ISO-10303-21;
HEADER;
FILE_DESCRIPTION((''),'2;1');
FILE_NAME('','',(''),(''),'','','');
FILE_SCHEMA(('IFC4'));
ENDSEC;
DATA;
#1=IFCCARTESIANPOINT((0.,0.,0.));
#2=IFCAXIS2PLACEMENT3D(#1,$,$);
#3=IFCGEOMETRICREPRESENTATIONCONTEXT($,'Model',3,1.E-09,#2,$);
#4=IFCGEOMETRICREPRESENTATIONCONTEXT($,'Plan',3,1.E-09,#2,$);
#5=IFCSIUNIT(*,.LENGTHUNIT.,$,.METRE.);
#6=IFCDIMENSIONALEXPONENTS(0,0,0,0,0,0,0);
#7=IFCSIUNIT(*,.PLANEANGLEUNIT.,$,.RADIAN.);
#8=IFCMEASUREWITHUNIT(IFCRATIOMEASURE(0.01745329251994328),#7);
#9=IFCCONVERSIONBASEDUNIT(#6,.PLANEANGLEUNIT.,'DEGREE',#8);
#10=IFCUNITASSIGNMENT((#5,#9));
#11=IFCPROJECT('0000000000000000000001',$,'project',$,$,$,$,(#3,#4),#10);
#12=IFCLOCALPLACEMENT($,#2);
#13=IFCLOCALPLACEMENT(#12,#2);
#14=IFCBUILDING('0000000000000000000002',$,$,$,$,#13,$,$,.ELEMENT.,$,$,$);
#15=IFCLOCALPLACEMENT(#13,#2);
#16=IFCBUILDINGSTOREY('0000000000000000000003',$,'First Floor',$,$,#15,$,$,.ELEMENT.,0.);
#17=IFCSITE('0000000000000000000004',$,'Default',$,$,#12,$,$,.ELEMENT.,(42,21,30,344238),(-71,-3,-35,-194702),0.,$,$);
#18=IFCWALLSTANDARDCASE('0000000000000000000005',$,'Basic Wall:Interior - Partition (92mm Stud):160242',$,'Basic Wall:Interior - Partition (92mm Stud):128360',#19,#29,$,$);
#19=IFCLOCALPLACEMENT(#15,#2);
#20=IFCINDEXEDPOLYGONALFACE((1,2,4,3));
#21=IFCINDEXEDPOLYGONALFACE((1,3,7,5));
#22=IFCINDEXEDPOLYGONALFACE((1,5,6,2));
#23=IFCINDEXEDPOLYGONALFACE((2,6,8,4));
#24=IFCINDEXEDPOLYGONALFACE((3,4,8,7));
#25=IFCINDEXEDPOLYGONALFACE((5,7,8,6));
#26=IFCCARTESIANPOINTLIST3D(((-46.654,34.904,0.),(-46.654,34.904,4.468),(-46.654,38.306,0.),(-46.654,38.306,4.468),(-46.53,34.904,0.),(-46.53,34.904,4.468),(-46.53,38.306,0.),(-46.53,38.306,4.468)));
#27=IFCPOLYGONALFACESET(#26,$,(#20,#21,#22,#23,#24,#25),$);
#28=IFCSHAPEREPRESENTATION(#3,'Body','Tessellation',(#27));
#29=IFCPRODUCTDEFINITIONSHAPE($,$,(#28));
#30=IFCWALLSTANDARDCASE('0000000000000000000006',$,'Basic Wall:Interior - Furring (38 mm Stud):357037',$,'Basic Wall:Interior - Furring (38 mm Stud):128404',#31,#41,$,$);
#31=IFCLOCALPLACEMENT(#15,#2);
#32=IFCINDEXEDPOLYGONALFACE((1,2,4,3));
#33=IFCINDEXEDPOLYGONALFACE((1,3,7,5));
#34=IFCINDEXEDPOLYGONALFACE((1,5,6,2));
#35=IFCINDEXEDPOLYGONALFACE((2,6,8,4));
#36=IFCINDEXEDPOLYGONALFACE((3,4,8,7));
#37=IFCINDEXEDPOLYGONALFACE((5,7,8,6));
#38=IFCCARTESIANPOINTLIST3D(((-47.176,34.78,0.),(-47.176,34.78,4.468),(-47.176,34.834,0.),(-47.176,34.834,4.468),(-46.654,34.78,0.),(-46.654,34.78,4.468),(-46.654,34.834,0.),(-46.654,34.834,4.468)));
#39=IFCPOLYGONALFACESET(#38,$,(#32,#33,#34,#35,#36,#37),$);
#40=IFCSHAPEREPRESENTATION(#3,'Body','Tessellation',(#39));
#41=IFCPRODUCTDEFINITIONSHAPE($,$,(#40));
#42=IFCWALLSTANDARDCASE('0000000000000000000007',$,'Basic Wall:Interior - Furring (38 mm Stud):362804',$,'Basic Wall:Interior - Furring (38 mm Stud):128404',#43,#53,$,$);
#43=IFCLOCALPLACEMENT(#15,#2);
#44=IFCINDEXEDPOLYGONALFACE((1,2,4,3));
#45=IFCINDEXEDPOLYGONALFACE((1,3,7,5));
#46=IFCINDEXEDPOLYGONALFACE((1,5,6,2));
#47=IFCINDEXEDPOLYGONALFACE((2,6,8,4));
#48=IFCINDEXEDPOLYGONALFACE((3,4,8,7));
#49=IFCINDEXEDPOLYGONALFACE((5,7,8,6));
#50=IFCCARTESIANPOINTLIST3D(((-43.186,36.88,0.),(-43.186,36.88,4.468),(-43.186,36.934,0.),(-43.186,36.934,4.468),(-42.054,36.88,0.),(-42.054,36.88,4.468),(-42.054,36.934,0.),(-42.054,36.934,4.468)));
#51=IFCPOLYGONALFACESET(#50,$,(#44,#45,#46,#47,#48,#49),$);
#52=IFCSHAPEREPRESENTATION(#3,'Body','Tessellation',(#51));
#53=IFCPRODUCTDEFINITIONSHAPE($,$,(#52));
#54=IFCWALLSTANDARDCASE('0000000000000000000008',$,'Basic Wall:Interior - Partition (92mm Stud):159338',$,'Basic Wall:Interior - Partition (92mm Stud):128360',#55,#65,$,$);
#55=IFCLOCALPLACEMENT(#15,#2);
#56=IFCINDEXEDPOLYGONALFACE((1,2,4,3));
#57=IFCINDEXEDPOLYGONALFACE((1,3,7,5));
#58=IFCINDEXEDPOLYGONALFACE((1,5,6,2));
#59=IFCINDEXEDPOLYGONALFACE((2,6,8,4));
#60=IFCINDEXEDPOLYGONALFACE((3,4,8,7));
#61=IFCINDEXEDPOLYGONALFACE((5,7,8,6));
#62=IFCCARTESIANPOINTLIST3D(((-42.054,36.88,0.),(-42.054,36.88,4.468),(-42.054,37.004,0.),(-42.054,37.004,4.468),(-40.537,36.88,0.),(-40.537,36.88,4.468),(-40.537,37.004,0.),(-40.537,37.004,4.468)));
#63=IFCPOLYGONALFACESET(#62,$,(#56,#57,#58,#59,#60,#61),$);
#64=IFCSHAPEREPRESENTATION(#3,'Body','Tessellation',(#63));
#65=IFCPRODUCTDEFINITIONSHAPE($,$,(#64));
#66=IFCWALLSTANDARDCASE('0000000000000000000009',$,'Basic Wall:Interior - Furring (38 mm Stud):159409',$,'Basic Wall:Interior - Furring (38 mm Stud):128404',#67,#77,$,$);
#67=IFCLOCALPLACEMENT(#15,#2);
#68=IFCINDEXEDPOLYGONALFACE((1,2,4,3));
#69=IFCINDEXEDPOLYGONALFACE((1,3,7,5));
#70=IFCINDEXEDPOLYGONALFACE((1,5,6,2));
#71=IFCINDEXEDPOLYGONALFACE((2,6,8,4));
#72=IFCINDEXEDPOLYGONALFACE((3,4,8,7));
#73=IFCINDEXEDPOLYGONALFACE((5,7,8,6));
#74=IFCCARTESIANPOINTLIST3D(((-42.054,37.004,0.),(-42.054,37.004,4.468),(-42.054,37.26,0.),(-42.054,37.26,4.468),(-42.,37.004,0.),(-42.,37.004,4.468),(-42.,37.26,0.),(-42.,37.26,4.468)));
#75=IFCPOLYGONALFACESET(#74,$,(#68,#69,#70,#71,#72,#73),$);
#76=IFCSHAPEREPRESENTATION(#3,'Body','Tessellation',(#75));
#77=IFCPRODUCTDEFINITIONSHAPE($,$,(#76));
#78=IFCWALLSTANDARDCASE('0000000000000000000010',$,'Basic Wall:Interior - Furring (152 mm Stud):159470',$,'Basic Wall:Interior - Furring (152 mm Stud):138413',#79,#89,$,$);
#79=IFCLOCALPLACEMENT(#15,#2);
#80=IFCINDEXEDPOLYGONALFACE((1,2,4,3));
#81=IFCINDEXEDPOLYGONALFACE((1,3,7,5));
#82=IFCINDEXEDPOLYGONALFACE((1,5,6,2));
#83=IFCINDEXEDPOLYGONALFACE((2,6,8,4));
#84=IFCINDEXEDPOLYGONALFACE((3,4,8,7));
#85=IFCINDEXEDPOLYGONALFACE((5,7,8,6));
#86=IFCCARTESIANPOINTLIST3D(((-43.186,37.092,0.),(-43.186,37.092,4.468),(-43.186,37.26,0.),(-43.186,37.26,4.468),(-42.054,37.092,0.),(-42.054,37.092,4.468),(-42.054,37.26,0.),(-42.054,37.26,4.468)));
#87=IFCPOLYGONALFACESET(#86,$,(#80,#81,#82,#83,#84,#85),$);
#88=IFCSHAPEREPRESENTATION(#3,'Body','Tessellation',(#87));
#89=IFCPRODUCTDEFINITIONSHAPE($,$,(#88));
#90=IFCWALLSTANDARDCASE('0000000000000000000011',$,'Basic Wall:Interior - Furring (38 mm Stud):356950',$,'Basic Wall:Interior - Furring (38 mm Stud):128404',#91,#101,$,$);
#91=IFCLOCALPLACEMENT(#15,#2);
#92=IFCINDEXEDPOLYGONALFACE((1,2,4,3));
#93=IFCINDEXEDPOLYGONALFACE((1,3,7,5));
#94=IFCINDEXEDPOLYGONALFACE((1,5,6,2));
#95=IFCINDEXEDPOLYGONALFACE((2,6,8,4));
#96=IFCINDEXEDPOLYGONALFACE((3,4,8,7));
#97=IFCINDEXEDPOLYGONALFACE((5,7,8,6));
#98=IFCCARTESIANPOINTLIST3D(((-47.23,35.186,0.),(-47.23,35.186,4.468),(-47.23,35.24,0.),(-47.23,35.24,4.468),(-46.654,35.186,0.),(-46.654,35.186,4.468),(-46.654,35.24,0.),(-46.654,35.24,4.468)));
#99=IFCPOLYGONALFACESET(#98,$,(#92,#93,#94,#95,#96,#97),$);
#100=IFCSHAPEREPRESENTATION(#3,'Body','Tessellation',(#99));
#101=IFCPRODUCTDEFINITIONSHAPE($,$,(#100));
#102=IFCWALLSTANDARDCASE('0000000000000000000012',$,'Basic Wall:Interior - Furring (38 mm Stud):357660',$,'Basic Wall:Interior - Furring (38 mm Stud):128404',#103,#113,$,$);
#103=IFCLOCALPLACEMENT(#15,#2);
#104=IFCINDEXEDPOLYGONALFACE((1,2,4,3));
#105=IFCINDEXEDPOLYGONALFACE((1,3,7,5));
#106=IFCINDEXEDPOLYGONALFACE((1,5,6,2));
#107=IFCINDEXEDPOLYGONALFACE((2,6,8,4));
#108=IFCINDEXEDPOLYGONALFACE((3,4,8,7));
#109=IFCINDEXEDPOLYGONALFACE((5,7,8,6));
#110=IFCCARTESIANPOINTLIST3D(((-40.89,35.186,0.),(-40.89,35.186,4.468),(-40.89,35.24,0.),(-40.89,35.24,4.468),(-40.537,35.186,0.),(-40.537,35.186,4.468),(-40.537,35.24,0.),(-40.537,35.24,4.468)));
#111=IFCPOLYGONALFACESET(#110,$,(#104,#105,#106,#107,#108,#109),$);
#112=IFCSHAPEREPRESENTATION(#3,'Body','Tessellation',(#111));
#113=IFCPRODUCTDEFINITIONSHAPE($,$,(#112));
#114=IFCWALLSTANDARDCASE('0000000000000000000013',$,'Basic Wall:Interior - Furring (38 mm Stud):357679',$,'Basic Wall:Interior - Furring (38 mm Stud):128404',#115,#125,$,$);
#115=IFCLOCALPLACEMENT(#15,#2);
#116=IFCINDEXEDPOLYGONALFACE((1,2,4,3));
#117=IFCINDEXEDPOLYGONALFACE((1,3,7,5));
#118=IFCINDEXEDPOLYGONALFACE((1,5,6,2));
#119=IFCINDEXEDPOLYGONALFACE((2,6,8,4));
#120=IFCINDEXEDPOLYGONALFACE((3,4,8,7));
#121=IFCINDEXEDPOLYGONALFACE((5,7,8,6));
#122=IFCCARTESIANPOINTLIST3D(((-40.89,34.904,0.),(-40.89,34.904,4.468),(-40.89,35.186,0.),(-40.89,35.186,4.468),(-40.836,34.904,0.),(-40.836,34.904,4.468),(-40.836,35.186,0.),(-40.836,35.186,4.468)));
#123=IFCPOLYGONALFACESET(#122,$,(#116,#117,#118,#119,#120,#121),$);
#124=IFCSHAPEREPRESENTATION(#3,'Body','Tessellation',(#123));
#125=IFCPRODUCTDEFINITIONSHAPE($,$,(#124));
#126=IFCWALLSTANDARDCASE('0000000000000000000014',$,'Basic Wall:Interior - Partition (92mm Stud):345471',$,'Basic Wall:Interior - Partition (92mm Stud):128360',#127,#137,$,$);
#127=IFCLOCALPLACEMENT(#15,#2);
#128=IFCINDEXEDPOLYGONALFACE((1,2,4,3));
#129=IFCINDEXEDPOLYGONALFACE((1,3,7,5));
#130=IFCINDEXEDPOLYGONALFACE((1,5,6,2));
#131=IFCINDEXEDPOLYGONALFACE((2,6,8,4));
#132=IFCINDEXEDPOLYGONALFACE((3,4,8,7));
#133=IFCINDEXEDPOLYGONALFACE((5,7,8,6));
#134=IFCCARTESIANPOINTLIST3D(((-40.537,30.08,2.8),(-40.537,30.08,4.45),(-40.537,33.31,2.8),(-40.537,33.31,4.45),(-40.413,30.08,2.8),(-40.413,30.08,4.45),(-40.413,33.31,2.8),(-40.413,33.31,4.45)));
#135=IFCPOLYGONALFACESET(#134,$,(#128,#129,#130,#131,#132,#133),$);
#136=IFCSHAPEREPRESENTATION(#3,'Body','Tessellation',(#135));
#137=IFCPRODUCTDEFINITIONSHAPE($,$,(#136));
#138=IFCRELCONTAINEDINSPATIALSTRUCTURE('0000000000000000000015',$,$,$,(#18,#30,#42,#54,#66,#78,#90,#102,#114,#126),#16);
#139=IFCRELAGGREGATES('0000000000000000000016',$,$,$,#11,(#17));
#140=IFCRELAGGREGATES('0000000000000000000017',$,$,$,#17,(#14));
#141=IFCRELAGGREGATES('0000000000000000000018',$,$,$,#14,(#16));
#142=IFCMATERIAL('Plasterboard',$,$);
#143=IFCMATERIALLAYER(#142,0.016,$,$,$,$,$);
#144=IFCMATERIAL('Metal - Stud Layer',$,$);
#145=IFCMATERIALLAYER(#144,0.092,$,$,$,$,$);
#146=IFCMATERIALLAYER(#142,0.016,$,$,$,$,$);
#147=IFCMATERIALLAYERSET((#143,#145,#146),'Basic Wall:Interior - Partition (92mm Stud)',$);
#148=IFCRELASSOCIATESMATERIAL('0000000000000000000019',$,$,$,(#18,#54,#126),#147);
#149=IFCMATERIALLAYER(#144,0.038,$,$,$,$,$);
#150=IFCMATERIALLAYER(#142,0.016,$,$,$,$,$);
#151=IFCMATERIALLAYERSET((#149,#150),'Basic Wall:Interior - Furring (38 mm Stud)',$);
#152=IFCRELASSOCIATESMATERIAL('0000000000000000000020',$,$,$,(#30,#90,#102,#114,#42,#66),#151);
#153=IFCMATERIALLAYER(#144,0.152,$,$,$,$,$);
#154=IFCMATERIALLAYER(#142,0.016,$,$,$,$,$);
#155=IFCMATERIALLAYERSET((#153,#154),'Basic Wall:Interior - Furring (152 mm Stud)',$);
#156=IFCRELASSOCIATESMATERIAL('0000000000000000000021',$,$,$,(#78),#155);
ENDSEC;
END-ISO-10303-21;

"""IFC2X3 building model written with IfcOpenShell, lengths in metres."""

from ifc_helpers import new_model, entity, si_unit, converted_unit, frame, frame_2d, origin, place, context, project, spatial, rectangle, extrude, material, layer, layer_set, layer_usage, element, save


model = new_model("IFC2X3")

# Units and contexts
model_context = context("Model", 3, precision=1e-09, world=origin())
plan_context = context("Plan", 3, precision=1e-09, world=origin())
ifc_project = project(units=[si_unit("LENGTHUNIT", "METRE"), converted_unit("PLANEANGLEUNIT", "DEGREE", entity("IfcRatioMeasure", 0.01745329251994328), si_unit("PLANEANGLEUNIT", "RADIAN"), dimensions=[0, 0, 0, 0, 0, 0, 0])], contexts=[model_context, plan_context])

# Site, building, storey
site_placement = place(None, origin())
site = spatial("IfcSite", under=ifc_project, at=site_placement, Name="Default", CompositionType="ELEMENT", RefLatitude=(42, 21, 30, 344238), RefLongitude=(-71, -3, -35, -194702), RefElevation=0.0)
building_placement = place(site_placement, origin())
building = spatial("IfcBuilding", under=site, at=building_placement, CompositionType="ELEMENT")
storey_placement = place(building_placement, origin())
storey = spatial("IfcBuildingStorey", under=building, at=storey_placement, Name="First Floor", CompositionType="ELEMENT", Elevation=0.0)

# Shared definitions
ifc_material_1 = material(Name="Plasterboard")
ifc_layer_1 = layer(ifc_material_1, 0.016)
ifc_material_2 = material(Name="Metal - Stud Layer")
ifc_layer_2 = layer(ifc_material_2, 0.092)
ifc_layer_3 = layer(ifc_material_1, 0.016)
ifc_layer_set_1 = layer_set([ifc_layer_1, ifc_layer_2, ifc_layer_3], Name="Basic Wall:Interior - Partition (92mm Stud)")
ifc_layer_usage_1 = layer_usage(ifc_layer_set_1, "AXIS2", "NEGATIVE", 0.062)

# Walls
wall_1_placement = place(storey_placement, frame((-46.592, 38.306, 0.0), z_axis=(0.0, 0.0, 1.0), x_axis=(0.0, -1.0, 0.0)))
element("IfcWallStandardCase", 1, at=wall_1_placement, inside=storey, material=ifc_layer_usage_1, Name="Basic Wall:Interior - Partition (92mm Stud):160242", ObjectType="Basic Wall:Interior - Partition (92mm Stud):128360", context=model_context, shape_type="SweptSolid", body=[
    extrude(rectangle(XDim=3.402, YDim=0.124, at=frame_2d((1.701, 0.0), x_axis=(-1.0, 0.0))), origin(), (0.0, 0.0, 1.0), 4.468),
])
ifc_layer_4 = layer(ifc_material_2, 0.038)
ifc_layer_5 = layer(ifc_material_1, 0.016)
ifc_layer_set_2 = layer_set([ifc_layer_4, ifc_layer_5], Name="Basic Wall:Interior - Furring (38 mm Stud)")
ifc_layer_usage_2 = layer_usage(ifc_layer_set_2, "AXIS2", "NEGATIVE", 0.027)
wall_2_placement = place(storey_placement, frame((-47.176, 34.807, 0.0)))
element("IfcWallStandardCase", 2, at=wall_2_placement, inside=storey, material=ifc_layer_usage_2, Name="Basic Wall:Interior - Furring (38 mm Stud):357037", ObjectType="Basic Wall:Interior - Furring (38 mm Stud):128404", context=model_context, shape_type="SweptSolid", body=[
    extrude(rectangle(XDim=0.522, YDim=0.054, at=frame_2d((0.261, 0.0), x_axis=(-1.0, 0.0))), origin(), (0.0, 0.0, 1.0), 4.468),
])
ifc_layer_usage_3 = layer_usage(ifc_layer_set_2, "AXIS2", "POSITIVE", -0.027)
wall_3_placement = place(storey_placement, frame((-42.054, 36.907, 0.0), z_axis=(0.0, 0.0, 1.0), x_axis=(-1.0, 0.0, 0.0)))
element("IfcWallStandardCase", 3, at=wall_3_placement, inside=storey, material=ifc_layer_usage_3, Name="Basic Wall:Interior - Furring (38 mm Stud):362804", ObjectType="Basic Wall:Interior - Furring (38 mm Stud):128404", context=model_context, shape_type="SweptSolid", body=[
    extrude(rectangle(XDim=1.132, YDim=0.054, at=frame_2d((0.566, 0.0), x_axis=(-1.0, 0.0))), origin(), (0.0, 0.0, 1.0), 4.468),
])
wall_4_placement = place(storey_placement, frame((-40.537, 36.942, 0.0), z_axis=(0.0, 0.0, 1.0), x_axis=(-1.0, 0.0, 0.0)))
element("IfcWallStandardCase", 4, at=wall_4_placement, inside=storey, material=ifc_layer_usage_1, Name="Basic Wall:Interior - Partition (92mm Stud):159338", ObjectType="Basic Wall:Interior - Partition (92mm Stud):128360", context=model_context, shape_type="SweptSolid", body=[
    extrude(rectangle(XDim=1.517, YDim=0.124, at=frame_2d((0.7585, 0.0), x_axis=(-1.0, 0.0))), origin(), (0.0, 0.0, 1.0), 4.468),
])
wall_5_placement = place(storey_placement, frame((-42.027, 37.26, 0.0), z_axis=(0.0, 0.0, 1.0), x_axis=(0.0, -1.0, 0.0)))
element("IfcWallStandardCase", 5, at=wall_5_placement, inside=storey, material=ifc_layer_usage_3, Name="Basic Wall:Interior - Furring (38 mm Stud):159409", ObjectType="Basic Wall:Interior - Furring (38 mm Stud):128404", context=model_context, shape_type="SweptSolid", body=[
    extrude(rectangle(XDim=0.256, YDim=0.054, at=frame_2d((0.128, 0.0), x_axis=(-1.0, 0.0))), origin(), (0.0, 0.0, 1.0), 4.468),
])
ifc_layer_6 = layer(ifc_material_2, 0.152)
ifc_layer_7 = layer(ifc_material_1, 0.016)
ifc_layer_set_3 = layer_set([ifc_layer_6, ifc_layer_7], Name="Basic Wall:Interior - Furring (152 mm Stud)")
ifc_layer_usage_4 = layer_usage(ifc_layer_set_3, "AXIS2", "POSITIVE", -0.084)
wall_6_placement = place(storey_placement, frame((-43.186, 37.176, 0.0)))
element("IfcWallStandardCase", 6, at=wall_6_placement, inside=storey, material=ifc_layer_usage_4, Name="Basic Wall:Interior - Furring (152 mm Stud):159470", ObjectType="Basic Wall:Interior - Furring (152 mm Stud):138413", context=model_context, shape_type="SweptSolid", body=[
    extrude(rectangle(XDim=1.132, YDim=0.168, at=frame_2d((0.566, 0.0), x_axis=(-1.0, 0.0))), origin(), (0.0, 0.0, 1.0), 4.468),
])
wall_7_placement = place(storey_placement, frame((-46.654, 35.213, 0.0), z_axis=(0.0, 0.0, 1.0), x_axis=(-1.0, 0.0, 0.0)))
element("IfcWallStandardCase", 7, at=wall_7_placement, inside=storey, material=ifc_layer_usage_2, Name="Basic Wall:Interior - Furring (38 mm Stud):356950", ObjectType="Basic Wall:Interior - Furring (38 mm Stud):128404", context=model_context, shape_type="SweptSolid", body=[
    extrude(rectangle(XDim=0.576, YDim=0.054, at=frame_2d((0.288, 0.0), x_axis=(-1.0, 0.0))), origin(), (0.0, 0.0, 1.0), 4.468),
])
wall_8_placement = place(storey_placement, frame((-40.537, 35.213, 0.0), z_axis=(0.0, 0.0, 1.0), x_axis=(-1.0, 0.0, 0.0)))
element("IfcWallStandardCase", 8, at=wall_8_placement, inside=storey, material=ifc_layer_usage_2, Name="Basic Wall:Interior - Furring (38 mm Stud):357660", ObjectType="Basic Wall:Interior - Furring (38 mm Stud):128404", context=model_context, shape_type="SweptSolid", body=[
    extrude(rectangle(XDim=0.353, YDim=0.054, at=frame_2d((0.1765, 0.0), x_axis=(-1.0, 0.0))), origin(), (0.0, 0.0, 1.0), 4.468),
])
wall_9_placement = place(storey_placement, frame((-40.863, 35.186, 0.0), z_axis=(0.0, 0.0, 1.0), x_axis=(0.0, -1.0, 0.0)))
element("IfcWallStandardCase", 9, at=wall_9_placement, inside=storey, material=ifc_layer_usage_2, Name="Basic Wall:Interior - Furring (38 mm Stud):357679", ObjectType="Basic Wall:Interior - Furring (38 mm Stud):128404", context=model_context, shape_type="SweptSolid", body=[
    extrude(rectangle(XDim=0.282, YDim=0.054, at=frame_2d((0.141, 0.0), x_axis=(-1.0, 0.0))), origin(), (0.0, 0.0, 1.0), 4.468),
])
wall_10_placement = place(storey_placement, frame((-40.475, 33.31, 2.8), z_axis=(0.0, 0.0, 1.0), x_axis=(0.0, -1.0, 0.0)))
element("IfcWallStandardCase", 10, at=wall_10_placement, inside=storey, material=ifc_layer_usage_1, Name="Basic Wall:Interior - Partition (92mm Stud):345471", ObjectType="Basic Wall:Interior - Partition (92mm Stud):128360", context=model_context, shape_type="SweptSolid", body=[
    extrude(rectangle(XDim=3.23, YDim=0.124, at=frame_2d((1.615, 0.0), x_axis=(-1.0, 0.0))), origin(), (0.0, 0.0, 1.0), 1.65),
])

save(model, "model.ifc")
